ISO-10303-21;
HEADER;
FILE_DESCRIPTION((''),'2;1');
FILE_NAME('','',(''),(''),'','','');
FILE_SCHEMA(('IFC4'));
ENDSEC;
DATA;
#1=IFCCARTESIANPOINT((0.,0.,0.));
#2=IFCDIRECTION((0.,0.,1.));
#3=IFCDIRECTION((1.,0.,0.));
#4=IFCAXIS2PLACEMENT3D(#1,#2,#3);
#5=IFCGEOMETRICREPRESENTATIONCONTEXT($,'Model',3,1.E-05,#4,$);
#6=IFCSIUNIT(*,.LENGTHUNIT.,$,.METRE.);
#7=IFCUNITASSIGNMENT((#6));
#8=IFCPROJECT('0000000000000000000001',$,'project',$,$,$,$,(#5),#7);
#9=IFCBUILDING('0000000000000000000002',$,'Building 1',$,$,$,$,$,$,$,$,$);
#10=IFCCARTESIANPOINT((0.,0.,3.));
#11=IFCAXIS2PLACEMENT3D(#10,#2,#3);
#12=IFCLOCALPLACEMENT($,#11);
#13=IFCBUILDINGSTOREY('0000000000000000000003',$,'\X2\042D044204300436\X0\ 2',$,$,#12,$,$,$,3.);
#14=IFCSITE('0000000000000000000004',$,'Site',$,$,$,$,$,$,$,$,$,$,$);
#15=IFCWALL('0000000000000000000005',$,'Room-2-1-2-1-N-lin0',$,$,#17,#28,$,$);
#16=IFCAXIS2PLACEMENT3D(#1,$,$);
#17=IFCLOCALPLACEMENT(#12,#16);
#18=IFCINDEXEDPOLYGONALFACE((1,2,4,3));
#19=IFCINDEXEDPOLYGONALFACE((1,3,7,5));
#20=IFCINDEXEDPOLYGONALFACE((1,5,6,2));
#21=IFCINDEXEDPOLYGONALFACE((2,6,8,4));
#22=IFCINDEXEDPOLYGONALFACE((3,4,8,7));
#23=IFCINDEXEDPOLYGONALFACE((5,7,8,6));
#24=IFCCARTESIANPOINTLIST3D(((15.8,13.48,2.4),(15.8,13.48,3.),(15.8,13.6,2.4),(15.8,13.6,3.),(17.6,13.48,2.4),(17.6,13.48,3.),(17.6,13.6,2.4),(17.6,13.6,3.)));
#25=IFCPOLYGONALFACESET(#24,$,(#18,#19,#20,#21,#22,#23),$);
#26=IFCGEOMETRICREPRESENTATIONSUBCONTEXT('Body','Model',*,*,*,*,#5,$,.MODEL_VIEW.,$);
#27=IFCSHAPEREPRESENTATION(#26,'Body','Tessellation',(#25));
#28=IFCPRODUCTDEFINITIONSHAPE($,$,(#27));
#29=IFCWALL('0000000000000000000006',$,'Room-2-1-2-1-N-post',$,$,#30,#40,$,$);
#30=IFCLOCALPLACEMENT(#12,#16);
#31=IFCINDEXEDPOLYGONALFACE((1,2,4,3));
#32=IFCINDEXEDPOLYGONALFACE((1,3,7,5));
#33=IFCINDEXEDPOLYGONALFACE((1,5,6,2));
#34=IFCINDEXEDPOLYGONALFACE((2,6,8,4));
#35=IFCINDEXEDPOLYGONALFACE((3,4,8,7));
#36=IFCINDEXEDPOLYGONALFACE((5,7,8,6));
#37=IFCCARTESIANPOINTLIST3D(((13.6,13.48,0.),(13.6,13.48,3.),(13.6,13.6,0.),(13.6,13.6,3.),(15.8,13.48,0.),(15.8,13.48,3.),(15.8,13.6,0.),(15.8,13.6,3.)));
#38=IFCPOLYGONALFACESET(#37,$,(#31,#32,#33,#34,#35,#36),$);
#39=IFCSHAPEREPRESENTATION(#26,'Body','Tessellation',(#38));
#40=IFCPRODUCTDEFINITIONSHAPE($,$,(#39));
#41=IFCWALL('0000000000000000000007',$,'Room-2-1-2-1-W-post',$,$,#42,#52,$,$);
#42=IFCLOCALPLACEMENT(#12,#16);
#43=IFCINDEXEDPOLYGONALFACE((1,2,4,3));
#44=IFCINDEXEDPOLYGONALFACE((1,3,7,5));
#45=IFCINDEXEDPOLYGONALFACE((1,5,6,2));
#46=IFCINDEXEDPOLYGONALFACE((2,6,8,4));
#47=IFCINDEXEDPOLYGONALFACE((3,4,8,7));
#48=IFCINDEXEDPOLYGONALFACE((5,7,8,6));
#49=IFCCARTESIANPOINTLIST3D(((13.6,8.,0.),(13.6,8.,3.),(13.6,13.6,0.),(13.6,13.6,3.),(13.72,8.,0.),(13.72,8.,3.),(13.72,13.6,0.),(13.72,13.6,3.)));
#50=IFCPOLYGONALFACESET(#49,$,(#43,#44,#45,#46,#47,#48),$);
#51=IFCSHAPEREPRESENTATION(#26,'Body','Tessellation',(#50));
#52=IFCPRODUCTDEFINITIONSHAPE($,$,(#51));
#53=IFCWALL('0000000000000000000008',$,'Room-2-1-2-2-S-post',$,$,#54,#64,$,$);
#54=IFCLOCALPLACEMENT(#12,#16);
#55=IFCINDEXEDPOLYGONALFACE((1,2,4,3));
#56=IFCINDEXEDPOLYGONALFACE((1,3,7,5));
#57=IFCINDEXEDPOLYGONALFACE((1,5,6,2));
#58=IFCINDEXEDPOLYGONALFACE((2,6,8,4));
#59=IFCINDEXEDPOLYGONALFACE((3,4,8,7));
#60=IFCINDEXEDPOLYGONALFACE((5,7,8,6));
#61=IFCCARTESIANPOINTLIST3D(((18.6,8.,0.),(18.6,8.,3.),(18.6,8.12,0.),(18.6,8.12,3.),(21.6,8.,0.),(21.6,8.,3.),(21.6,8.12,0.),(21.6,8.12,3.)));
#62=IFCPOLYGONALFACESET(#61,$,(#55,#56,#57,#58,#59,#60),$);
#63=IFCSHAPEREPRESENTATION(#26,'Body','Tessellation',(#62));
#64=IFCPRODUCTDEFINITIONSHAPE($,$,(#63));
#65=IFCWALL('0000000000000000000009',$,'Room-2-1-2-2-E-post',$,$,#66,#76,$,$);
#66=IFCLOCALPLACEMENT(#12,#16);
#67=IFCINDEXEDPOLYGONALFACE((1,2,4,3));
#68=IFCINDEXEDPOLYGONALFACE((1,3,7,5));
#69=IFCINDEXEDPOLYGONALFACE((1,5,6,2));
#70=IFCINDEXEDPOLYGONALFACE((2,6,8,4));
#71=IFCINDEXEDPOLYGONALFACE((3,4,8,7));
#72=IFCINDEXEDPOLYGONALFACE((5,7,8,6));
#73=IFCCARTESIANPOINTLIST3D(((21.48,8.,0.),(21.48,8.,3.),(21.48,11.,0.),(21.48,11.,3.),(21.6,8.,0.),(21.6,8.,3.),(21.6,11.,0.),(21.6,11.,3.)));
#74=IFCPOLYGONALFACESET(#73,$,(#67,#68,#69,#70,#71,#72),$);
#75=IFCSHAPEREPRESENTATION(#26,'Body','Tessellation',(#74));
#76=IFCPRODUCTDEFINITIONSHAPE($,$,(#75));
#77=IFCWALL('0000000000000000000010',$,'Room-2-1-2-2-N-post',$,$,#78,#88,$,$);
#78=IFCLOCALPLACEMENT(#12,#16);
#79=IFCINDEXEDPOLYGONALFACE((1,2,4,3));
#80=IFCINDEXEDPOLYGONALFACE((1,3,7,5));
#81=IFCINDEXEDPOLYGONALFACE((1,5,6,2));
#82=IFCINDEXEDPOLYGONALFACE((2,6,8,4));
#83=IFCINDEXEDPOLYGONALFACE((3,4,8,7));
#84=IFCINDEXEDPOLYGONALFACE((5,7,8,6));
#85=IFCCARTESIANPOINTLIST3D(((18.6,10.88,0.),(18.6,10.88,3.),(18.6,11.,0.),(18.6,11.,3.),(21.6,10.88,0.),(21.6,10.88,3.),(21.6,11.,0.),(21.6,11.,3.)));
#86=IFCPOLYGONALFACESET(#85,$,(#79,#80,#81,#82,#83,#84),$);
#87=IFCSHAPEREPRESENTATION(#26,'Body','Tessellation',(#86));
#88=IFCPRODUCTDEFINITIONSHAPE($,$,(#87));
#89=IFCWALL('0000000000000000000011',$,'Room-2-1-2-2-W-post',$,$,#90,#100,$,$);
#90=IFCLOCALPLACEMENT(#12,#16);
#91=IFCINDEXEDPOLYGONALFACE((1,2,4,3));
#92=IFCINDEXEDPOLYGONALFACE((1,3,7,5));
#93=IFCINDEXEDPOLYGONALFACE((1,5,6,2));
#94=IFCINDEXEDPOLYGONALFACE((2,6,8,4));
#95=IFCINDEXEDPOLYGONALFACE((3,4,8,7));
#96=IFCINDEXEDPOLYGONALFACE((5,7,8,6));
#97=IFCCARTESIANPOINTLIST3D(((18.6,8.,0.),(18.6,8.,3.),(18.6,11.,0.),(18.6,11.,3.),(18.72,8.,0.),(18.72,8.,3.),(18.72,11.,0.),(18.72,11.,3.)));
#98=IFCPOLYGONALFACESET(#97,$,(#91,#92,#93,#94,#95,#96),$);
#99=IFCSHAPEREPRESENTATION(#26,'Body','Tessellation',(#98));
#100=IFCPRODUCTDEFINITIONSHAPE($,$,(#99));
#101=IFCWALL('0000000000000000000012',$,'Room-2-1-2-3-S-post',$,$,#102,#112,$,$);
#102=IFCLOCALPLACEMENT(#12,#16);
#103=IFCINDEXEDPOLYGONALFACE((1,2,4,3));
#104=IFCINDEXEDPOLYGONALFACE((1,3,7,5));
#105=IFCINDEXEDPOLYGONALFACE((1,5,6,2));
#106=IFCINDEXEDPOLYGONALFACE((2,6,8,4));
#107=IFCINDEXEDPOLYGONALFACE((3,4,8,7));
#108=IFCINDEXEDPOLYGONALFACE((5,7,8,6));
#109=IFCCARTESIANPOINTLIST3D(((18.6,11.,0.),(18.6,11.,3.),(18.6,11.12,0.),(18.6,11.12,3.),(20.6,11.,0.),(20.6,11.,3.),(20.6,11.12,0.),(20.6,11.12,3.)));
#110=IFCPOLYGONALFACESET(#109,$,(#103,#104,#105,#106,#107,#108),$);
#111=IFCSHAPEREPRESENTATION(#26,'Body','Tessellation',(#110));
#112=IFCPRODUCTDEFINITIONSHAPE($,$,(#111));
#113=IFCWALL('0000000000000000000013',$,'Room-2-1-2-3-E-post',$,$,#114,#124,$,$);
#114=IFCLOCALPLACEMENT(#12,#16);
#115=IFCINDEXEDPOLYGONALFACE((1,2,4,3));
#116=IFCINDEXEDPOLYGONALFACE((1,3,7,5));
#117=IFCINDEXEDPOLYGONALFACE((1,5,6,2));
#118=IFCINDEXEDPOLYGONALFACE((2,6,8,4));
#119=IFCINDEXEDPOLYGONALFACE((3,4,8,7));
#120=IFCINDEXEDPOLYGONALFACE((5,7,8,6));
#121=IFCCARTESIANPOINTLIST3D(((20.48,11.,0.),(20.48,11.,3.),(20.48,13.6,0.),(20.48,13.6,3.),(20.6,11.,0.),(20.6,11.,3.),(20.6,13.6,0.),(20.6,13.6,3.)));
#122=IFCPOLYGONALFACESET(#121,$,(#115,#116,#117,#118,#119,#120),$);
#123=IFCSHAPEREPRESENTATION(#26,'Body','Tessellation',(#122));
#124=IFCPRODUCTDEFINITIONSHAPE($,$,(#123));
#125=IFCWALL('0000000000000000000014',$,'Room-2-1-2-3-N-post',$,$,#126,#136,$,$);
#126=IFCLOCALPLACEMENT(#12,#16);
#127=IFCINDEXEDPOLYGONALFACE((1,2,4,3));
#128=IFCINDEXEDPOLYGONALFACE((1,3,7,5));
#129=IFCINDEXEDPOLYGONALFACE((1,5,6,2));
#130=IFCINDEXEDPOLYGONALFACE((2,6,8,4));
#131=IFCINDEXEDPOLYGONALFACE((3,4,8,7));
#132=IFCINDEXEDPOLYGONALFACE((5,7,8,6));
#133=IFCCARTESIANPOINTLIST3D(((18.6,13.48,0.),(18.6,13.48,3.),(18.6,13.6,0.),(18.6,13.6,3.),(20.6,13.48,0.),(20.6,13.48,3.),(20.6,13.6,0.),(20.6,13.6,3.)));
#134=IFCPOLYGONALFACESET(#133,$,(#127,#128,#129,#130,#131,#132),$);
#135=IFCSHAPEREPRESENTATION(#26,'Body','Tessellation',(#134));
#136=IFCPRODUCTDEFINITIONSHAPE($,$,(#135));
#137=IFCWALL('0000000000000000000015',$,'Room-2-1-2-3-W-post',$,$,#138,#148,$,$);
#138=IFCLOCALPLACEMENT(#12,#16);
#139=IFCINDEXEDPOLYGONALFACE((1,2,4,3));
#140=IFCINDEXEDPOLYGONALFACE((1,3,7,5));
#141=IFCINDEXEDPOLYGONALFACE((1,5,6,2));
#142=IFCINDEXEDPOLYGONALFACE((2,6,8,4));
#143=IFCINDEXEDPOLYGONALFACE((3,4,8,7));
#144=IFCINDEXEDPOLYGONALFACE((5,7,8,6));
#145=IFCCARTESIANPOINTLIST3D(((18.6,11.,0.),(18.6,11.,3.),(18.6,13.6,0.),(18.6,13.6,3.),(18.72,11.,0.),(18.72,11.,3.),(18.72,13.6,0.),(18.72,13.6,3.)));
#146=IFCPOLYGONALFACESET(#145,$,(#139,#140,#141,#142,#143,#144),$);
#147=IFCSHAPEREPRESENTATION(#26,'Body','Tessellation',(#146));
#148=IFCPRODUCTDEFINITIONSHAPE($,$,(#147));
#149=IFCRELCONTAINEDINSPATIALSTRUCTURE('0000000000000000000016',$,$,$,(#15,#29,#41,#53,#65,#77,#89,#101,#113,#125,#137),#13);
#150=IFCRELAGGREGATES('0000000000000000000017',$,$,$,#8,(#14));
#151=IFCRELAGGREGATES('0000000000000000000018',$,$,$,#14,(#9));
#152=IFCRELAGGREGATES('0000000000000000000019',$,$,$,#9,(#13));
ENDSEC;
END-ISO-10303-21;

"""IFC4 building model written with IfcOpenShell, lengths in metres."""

from ifc_helpers import new_model, si_unit, frame, origin_with_axes, place, context, subcontext, project, spatial, indexed_curve, outline, extrude, element, save


model = new_model("IFC4")

# Units and contexts
model_context = context("Model", 3, precision=1e-05, world=origin_with_axes())
body_context = subcontext(model_context, "Body", "Model", "MODEL_VIEW")
ifc_project = project(units=[si_unit("LENGTHUNIT", "METRE")], contexts=[model_context])

# Site, building, storey
site = spatial("IfcSite", under=ifc_project, Name="Site")
building = spatial("IfcBuilding", under=site, Name="Building 1")
storey_placement = place(None, frame((0.0, 0.0, 3.0), z_axis=(0.0, 0.0, 1.0), x_axis=(1.0, 0.0, 0.0)))
storey = spatial("IfcBuildingStorey", under=building, at=storey_placement, Name="Этаж 2", Elevation=3.0)

# Walls
wall_1_placement = place(storey_placement, frame((17.6, 13.6, 2.4), z_axis=(0.0, 0.0, 1.0), x_axis=(-1.0, 0.0, 0.0)))
element("IfcWall", 1, at=wall_1_placement, inside=storey, Name="Room-2-1-2-1-N-lin0", context=body_context, shape_type="SweptSolid", body=[
    extrude(outline(indexed_curve([(0.0, 0.0), (0.0, 0.12), (1.8, 0.12), (1.8, 0.0), (0.0, 0.0)], self_intersect=False)), origin_with_axes(), (0.0, 0.0, 1.0), 0.6),
])
wall_2_placement = place(storey_placement, frame((15.8, 13.6, 0.0), z_axis=(0.0, 0.0, 1.0), x_axis=(-1.0, 0.0, 0.0)))
element("IfcWall", 2, at=wall_2_placement, inside=storey, Name="Room-2-1-2-1-N-post", context=body_context, shape_type="SweptSolid", body=[
    extrude(outline(indexed_curve([(0.0, 0.0), (0.0, 0.12), (2.2, 0.12), (2.2, 0.0), (0.0, 0.0)], self_intersect=False)), origin_with_axes(), (0.0, 0.0, 1.0), 3.0),
])
wall_3_placement = place(storey_placement, frame((13.6, 13.6, 0.0), z_axis=(0.0, 0.0, 1.0), x_axis=(0.0, -1.0, 0.0)))
element("IfcWall", 3, at=wall_3_placement, inside=storey, Name="Room-2-1-2-1-W-post", context=body_context, shape_type="SweptSolid", body=[
    extrude(outline(indexed_curve([(0.0, 0.0), (0.0, 0.12), (5.6, 0.12), (5.6, 0.0), (0.0, 0.0)], self_intersect=False)), origin_with_axes(), (0.0, 0.0, 1.0), 3.0),
])
for number, where, z_axis, x_axis, name in (
    (4, (18.6, 8.0, 0.0), (0.0, 0.0, 1.0), (1.0, 0.0, 0.0), "Room-2-1-2-2-S-post"),
    (5, (21.6, 8.0, 0.0), (0.0, 0.0, 1.0), (0.0, 1.0, 0.0), "Room-2-1-2-2-E-post"),
    (6, (21.6, 11.0, 0.0), (0.0, 0.0, 1.0), (-1.0, 0.0, 0.0), "Room-2-1-2-2-N-post"),
    (7, (18.6, 11.0, 0.0), (0.0, 0.0, 1.0), (0.0, -1.0, 0.0), "Room-2-1-2-2-W-post"),
):
    element("IfcWall", number, at=place(storey_placement, frame(where, z_axis=z_axis, x_axis=x_axis)), inside=storey, Name=name, context=body_context, shape_type="SweptSolid", body=[
        extrude(outline(indexed_curve([(0.0, 0.0), (0.0, 0.12), (3.0, 0.12), (3.0, 0.0), (0.0, 0.0)], self_intersect=False)), origin_with_axes(), (0.0, 0.0, 1.0), 3.0),
    ])
wall_4_placement = place(storey_placement, frame((18.6, 11.0, 0.0), z_axis=(0.0, 0.0, 1.0), x_axis=(1.0, 0.0, 0.0)))
element("IfcWall", 8, at=wall_4_placement, inside=storey, Name="Room-2-1-2-3-S-post", context=body_context, shape_type="SweptSolid", body=[
    extrude(outline(indexed_curve([(0.0, 0.0), (0.0, 0.12), (2.0, 0.12), (2.0, 0.0), (0.0, 0.0)], self_intersect=False)), origin_with_axes(), (0.0, 0.0, 1.0), 3.0),
])
wall_5_placement = place(storey_placement, frame((20.6, 11.0, 0.0), z_axis=(0.0, 0.0, 1.0), x_axis=(0.0, 1.0, 0.0)))
element("IfcWall", 9, at=wall_5_placement, inside=storey, Name="Room-2-1-2-3-E-post", context=body_context, shape_type="SweptSolid", body=[
    extrude(outline(indexed_curve([(0.0, 0.0), (0.0, 0.12), (2.6, 0.12), (2.6, 0.0), (0.0, 0.0)], self_intersect=False)), origin_with_axes(), (0.0, 0.0, 1.0), 3.0),
])
wall_6_placement = place(storey_placement, frame((20.6, 13.6, 0.0), z_axis=(0.0, 0.0, 1.0), x_axis=(-1.0, 0.0, 0.0)))
element("IfcWall", 10, at=wall_6_placement, inside=storey, Name="Room-2-1-2-3-N-post", context=body_context, shape_type="SweptSolid", body=[
    extrude(outline(indexed_curve([(0.0, 0.0), (0.0, 0.12), (2.0, 0.12), (2.0, 0.0), (0.0, 0.0)], self_intersect=False)), origin_with_axes(), (0.0, 0.0, 1.0), 3.0),
])
wall_7_placement = place(storey_placement, frame((18.6, 13.6, 0.0), z_axis=(0.0, 0.0, 1.0), x_axis=(0.0, -1.0, 0.0)))
element("IfcWall", 11, at=wall_7_placement, inside=storey, Name="Room-2-1-2-3-W-post", context=body_context, shape_type="SweptSolid", body=[
    extrude(outline(indexed_curve([(0.0, 0.0), (0.0, 0.12), (2.6, 0.12), (2.6, 0.0), (0.0, 0.0)], self_intersect=False)), origin_with_axes(), (0.0, 0.0, 1.0), 3.0),
])

save(model, "model.ifc")
